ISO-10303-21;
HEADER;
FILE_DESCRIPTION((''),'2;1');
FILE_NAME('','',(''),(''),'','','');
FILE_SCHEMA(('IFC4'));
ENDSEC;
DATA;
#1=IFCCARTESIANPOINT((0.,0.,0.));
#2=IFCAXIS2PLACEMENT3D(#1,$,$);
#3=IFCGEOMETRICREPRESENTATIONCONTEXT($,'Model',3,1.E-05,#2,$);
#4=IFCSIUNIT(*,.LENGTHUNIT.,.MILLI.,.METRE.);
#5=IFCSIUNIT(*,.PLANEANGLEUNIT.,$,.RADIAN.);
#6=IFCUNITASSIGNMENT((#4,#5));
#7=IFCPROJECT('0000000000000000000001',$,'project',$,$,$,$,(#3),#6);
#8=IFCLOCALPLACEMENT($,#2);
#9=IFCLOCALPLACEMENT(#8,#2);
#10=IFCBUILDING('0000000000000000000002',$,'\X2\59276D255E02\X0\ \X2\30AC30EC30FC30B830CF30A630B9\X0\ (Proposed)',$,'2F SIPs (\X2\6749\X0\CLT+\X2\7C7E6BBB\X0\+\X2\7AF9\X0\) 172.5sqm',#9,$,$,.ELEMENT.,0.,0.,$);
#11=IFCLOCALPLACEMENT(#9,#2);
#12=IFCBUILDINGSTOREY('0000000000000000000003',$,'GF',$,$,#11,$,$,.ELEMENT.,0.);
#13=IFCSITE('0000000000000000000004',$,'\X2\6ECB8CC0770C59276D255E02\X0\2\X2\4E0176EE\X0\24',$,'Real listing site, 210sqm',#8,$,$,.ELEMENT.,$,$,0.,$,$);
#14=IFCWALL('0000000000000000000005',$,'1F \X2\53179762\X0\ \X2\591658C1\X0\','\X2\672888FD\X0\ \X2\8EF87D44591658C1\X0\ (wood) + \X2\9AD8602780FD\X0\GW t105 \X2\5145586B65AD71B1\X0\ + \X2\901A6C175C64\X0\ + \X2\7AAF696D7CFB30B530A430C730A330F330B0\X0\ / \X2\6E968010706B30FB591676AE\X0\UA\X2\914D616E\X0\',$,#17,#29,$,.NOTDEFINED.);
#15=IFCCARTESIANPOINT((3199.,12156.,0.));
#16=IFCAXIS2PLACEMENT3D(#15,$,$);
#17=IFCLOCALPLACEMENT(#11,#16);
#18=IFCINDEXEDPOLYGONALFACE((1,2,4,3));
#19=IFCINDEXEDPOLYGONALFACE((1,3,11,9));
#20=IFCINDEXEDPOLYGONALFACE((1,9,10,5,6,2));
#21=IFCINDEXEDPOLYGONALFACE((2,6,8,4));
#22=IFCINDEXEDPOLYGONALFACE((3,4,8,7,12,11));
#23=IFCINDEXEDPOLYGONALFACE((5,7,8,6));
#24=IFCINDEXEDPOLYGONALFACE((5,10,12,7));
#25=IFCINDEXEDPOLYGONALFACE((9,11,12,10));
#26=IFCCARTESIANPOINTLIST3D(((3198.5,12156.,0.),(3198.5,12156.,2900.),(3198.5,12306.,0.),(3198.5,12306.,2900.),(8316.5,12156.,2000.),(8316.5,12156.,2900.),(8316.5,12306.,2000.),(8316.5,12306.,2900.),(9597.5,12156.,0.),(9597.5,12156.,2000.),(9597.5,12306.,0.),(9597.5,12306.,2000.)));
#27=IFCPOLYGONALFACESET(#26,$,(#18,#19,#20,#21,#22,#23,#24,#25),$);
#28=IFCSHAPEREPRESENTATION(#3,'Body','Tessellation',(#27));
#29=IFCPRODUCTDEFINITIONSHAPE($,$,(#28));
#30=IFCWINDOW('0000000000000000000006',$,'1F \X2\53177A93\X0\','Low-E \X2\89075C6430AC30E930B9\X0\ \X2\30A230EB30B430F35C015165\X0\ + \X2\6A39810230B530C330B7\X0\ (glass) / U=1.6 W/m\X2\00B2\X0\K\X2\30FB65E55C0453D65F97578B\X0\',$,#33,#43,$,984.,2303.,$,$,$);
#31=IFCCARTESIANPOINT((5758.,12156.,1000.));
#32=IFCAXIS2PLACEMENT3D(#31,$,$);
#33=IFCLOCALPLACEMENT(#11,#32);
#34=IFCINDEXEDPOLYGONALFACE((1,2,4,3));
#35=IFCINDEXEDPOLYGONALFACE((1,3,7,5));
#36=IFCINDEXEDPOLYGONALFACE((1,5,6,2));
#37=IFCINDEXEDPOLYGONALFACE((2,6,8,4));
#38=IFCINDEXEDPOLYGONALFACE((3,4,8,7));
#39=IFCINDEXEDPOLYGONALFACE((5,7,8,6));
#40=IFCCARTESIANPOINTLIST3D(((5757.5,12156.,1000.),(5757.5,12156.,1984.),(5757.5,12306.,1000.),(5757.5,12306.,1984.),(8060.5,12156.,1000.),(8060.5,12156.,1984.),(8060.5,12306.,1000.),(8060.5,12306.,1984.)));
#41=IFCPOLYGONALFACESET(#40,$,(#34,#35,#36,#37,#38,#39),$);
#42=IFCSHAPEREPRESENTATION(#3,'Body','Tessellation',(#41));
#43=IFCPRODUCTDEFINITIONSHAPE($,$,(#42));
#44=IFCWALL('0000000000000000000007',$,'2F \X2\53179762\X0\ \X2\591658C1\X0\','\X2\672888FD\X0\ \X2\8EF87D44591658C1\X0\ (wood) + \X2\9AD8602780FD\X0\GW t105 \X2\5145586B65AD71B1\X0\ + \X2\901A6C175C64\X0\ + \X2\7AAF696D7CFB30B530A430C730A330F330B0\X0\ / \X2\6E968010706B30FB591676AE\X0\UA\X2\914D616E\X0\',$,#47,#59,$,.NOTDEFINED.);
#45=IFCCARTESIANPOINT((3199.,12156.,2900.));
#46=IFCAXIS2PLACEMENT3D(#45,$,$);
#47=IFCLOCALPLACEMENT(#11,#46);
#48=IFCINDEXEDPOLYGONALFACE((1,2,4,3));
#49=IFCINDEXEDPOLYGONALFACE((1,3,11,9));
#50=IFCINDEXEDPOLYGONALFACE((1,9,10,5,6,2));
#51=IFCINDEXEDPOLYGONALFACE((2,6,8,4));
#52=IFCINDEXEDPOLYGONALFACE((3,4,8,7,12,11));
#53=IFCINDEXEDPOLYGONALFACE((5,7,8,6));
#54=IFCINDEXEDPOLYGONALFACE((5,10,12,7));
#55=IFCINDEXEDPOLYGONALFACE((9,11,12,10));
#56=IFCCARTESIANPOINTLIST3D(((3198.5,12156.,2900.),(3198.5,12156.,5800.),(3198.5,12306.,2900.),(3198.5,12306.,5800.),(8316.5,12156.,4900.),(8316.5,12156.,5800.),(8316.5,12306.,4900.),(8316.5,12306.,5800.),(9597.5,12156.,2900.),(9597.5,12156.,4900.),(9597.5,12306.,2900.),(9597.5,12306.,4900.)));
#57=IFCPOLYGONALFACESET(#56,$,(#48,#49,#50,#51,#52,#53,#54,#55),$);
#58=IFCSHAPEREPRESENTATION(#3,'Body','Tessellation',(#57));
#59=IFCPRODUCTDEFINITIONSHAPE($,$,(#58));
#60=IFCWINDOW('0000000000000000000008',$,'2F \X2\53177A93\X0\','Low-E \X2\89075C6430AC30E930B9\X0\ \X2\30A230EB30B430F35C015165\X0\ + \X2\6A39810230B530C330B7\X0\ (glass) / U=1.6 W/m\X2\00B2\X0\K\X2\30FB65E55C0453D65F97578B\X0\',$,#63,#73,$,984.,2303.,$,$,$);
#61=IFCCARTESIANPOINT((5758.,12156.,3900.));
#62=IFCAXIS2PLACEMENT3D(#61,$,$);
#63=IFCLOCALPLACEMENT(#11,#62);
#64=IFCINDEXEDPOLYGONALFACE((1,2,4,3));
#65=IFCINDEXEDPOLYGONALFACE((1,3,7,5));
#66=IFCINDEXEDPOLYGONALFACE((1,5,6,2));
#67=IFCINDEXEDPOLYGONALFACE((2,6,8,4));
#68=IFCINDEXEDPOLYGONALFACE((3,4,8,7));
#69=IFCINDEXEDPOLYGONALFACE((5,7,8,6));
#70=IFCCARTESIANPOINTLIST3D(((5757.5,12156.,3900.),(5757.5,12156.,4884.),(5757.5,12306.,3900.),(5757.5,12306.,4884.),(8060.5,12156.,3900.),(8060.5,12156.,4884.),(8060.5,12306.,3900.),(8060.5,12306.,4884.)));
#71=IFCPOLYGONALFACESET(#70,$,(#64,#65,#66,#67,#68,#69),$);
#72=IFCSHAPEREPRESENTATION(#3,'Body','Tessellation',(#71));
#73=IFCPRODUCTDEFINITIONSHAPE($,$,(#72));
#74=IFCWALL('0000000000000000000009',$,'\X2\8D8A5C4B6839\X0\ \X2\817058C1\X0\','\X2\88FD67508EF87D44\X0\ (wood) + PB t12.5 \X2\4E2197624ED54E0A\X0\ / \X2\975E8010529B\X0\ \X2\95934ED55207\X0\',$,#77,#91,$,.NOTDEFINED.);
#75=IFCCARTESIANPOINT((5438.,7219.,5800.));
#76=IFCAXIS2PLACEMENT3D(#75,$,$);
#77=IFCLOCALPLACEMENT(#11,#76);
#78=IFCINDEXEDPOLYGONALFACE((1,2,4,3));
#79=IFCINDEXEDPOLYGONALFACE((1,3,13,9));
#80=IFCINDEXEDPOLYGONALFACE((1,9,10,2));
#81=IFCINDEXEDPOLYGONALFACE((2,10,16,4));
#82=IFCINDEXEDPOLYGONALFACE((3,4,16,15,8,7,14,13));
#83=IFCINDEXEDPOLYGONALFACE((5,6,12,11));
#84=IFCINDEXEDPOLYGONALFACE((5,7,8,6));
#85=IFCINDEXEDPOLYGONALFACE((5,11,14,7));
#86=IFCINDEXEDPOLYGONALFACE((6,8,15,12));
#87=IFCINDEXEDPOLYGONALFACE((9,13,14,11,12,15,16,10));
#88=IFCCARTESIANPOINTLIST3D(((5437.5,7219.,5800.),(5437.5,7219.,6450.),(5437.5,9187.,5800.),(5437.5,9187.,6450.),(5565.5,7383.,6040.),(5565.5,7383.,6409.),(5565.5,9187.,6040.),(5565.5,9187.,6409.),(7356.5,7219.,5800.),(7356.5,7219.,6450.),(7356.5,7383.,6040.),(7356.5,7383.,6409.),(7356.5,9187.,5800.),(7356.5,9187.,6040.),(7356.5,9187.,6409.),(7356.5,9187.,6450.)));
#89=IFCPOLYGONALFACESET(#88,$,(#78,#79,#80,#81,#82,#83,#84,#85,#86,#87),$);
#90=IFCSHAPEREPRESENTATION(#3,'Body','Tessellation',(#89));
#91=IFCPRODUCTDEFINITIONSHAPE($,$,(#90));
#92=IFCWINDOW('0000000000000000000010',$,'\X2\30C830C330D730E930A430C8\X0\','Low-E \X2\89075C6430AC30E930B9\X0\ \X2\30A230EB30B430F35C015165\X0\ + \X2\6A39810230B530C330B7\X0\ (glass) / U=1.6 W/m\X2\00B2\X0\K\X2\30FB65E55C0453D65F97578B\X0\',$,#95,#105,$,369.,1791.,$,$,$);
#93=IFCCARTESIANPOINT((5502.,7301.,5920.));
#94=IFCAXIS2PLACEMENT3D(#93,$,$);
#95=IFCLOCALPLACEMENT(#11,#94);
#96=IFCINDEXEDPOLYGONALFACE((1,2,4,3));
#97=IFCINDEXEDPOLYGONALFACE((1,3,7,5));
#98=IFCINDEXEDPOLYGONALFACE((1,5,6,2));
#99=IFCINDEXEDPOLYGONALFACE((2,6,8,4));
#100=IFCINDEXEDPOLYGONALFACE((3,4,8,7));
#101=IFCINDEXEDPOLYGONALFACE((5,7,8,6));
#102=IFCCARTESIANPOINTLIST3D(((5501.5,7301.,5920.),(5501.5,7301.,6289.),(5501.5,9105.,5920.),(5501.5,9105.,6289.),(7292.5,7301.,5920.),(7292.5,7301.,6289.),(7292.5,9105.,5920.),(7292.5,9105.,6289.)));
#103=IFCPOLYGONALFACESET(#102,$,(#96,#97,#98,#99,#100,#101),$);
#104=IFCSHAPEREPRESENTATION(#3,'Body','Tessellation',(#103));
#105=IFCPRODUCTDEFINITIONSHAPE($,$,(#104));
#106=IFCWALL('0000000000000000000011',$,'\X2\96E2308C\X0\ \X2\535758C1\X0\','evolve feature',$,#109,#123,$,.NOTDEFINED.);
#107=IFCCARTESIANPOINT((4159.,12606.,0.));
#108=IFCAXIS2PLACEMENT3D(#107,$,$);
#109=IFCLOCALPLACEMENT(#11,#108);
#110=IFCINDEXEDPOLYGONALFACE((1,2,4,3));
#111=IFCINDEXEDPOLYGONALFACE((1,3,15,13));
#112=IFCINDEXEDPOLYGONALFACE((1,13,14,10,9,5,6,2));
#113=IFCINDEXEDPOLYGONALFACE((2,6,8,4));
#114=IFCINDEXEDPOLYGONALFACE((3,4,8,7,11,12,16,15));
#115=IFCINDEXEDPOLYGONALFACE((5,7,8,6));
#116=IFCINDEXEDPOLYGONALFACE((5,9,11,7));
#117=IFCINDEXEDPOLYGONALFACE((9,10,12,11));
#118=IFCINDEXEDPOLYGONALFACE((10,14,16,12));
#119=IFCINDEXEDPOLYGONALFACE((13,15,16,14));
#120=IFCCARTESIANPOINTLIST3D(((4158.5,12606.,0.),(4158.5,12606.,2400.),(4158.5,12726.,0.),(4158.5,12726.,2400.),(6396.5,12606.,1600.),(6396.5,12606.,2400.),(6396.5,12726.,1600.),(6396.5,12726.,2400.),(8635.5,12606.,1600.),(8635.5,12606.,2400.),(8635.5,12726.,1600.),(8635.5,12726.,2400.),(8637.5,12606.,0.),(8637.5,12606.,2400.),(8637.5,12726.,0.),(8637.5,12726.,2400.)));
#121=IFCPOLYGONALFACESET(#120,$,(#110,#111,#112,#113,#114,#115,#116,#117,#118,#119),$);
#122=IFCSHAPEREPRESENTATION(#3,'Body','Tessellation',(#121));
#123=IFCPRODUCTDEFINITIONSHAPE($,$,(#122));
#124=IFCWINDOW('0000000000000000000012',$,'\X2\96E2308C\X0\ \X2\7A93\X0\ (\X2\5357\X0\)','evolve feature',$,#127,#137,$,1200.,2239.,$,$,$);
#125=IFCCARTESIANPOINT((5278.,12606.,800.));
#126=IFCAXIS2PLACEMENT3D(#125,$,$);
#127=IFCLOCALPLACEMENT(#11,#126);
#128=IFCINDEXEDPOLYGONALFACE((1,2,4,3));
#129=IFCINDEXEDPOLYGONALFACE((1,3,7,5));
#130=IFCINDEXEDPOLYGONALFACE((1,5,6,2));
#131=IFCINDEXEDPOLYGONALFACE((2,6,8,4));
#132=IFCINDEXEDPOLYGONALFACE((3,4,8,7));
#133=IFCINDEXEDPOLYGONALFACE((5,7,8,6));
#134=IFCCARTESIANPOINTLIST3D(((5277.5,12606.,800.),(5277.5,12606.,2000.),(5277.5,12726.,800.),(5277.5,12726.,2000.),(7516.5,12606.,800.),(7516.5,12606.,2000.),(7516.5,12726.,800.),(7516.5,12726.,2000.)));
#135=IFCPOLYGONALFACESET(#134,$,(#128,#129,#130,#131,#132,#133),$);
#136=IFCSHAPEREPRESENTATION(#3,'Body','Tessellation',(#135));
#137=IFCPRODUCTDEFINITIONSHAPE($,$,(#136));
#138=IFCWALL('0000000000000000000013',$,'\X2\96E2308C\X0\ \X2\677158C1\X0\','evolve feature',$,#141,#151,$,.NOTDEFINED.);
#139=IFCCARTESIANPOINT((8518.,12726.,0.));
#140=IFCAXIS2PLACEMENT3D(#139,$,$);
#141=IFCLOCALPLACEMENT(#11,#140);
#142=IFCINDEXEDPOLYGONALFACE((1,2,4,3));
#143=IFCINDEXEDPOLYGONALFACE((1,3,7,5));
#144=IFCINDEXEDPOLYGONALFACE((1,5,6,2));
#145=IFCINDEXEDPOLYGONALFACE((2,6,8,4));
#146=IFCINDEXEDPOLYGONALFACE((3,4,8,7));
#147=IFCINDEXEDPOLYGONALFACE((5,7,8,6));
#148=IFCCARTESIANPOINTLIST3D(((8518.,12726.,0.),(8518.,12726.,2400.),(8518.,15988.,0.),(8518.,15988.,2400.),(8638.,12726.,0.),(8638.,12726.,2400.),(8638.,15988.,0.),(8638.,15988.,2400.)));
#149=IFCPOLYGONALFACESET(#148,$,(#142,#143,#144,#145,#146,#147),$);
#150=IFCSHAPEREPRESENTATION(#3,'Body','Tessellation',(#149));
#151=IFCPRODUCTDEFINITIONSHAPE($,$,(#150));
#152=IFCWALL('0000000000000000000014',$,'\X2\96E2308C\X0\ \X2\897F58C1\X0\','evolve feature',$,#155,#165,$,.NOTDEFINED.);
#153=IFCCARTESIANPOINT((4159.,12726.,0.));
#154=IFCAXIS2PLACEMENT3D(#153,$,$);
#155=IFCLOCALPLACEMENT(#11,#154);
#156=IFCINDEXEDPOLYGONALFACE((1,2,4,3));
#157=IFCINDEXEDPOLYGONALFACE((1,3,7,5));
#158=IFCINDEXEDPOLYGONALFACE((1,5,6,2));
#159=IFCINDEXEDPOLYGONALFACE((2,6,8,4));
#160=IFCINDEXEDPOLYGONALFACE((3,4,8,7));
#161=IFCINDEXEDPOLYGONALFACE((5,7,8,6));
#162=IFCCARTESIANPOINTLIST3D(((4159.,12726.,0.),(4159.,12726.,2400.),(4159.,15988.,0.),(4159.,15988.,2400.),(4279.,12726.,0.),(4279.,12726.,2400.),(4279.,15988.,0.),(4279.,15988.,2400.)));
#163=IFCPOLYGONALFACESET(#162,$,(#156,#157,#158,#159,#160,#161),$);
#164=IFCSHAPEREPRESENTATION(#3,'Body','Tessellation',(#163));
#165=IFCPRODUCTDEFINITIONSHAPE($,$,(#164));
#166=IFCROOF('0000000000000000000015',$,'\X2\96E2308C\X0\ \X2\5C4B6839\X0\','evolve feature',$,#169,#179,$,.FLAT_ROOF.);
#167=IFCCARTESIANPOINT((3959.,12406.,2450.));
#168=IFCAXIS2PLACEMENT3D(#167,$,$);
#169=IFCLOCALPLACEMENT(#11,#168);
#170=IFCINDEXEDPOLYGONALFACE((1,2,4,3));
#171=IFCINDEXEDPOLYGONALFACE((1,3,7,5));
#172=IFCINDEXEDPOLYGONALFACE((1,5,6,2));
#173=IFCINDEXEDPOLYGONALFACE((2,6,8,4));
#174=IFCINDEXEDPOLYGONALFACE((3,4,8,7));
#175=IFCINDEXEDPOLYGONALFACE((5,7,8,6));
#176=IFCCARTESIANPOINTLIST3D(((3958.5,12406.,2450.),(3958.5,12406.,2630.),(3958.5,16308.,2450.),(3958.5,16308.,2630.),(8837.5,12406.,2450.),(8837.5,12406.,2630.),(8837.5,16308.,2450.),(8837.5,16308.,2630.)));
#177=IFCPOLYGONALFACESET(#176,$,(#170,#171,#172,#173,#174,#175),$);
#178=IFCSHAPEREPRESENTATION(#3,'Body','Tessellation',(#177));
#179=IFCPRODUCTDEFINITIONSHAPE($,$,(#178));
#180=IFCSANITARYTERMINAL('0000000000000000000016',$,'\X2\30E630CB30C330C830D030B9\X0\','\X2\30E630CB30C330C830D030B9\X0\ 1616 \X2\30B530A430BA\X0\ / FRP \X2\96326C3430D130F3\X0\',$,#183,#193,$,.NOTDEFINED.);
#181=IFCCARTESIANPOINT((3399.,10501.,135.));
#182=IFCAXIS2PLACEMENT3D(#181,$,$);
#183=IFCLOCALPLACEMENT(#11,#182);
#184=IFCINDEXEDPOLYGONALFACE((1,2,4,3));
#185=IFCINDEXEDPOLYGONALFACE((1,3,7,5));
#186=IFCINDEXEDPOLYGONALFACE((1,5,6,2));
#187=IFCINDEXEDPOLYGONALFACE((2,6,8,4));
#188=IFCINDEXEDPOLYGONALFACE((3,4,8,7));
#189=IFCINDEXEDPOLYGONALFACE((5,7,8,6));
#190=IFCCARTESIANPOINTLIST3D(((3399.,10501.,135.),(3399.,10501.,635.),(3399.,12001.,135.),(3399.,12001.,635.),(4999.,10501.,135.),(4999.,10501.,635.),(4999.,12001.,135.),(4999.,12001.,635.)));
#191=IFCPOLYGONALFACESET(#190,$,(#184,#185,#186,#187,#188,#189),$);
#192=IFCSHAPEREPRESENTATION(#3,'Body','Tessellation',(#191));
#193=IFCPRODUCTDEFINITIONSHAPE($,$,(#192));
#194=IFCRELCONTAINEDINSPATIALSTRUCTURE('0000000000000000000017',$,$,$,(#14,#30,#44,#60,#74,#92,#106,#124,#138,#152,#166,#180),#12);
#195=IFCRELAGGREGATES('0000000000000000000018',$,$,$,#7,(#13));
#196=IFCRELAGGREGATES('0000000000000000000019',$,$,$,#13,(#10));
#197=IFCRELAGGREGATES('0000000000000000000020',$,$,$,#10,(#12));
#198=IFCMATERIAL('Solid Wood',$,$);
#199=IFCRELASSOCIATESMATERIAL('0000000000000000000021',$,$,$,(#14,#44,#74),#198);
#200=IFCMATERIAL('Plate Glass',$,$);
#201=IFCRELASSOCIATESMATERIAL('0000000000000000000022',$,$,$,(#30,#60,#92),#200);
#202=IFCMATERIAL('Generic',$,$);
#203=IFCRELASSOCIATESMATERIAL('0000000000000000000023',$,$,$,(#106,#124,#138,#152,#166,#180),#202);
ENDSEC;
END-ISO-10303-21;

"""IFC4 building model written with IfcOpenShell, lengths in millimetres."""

from ifc_helpers import new_model, si_unit, frame, frame_2d, origin, place, context, project, spatial, rectangle, extrude, material, element, fill, save


model = new_model("IFC4")

# Units and contexts
model_context = context("Model", 3, precision=1e-05, world=origin())
ifc_project = project(units=[si_unit("LENGTHUNIT", "METRE", prefix="MILLI"), si_unit("PLANEANGLEUNIT", "RADIAN")], contexts=[model_context])

# Site, building, storey
site_placement = place(None, origin())
site = spatial("IfcSite", under=ifc_project, at=site_placement, Name="滋賀県大津市2丁目24", ObjectType="Real listing site, 210sqm", CompositionType="ELEMENT", RefElevation=0.0)
building_placement = place(site_placement, origin())
building = spatial("IfcBuilding", under=site, at=building_placement, Name="大津市 ガレージハウス (Proposed)", ObjectType="2F SIPs (杉CLT+籾殻+竹) 172.5sqm", CompositionType="ELEMENT", ElevationOfRefHeight=0.0, ElevationOfTerrain=0.0)
storey_placement = place(building_placement, origin())
storey = spatial("IfcBuildingStorey", under=building, at=storey_placement, Name="GF", CompositionType="ELEMENT", Elevation=0.0)

# Shared definitions
ifc_material_1 = material(Name="Generic")

# Wall, opening, window
ifc_material_2 = material(Name="Solid Wood")
wall_1_placement = place(storey_placement, frame((3199.0, 12156.0, 0.0)))
wall_1 = element("IfcWall", 1, at=wall_1_placement, inside=storey, material=ifc_material_2, Name="1F 北面 外壁", Description="木製 軸組外壁 (wood) + 高性能GW t105 充填断熱 + 通気層 + 窯業系サイディング / 準耐火・外皮UA配慮", PredefinedType="NOTDEFINED", context=model_context, shape_type="SweptSolid", body=[
    extrude(rectangle(XDim=6399.0, YDim=150.0, at=frame_2d((3199.0, 75.0))), frame((3199.0, 12156.0, 0.0)), (0.0, 0.0, 1.0), 2900.0),
])
opening_1_placement = place(storey_placement, frame((5758.0, 12156.0, 1000.0)))
opening_1 = element("IfcOpeningElement", 2, at=opening_1_placement, cuts=wall_1, PredefinedType="NOTDEFINED", context=model_context, shape_type="SweptSolid", body=[
    extrude(rectangle(XDim=2303.0, YDim=150.0, at=frame_2d((1151.0, 75.0))), frame((5758.0, 12156.0, 1000.0)), (0.0, 0.0, 1.0), 984.0),
])
ifc_material_3 = material(Name="Plate Glass")
window_1_placement = place(storey_placement, frame((5758.0, 12156.0, 1000.0)))
window_1 = element("IfcWindow", 3, at=window_1_placement, inside=storey, material=ifc_material_3, Name="1F 北窓", Description="Low-E 複層ガラス アルゴン封入 + 樹脂サッシ (glass) / U=1.6 W/m²K・日射取得型", OverallHeight=984.0, OverallWidth=2303.0, context=model_context, shape_type="SweptSolid", body=[
    extrude(rectangle(XDim=2303.0, YDim=150.0, at=frame_2d((1151.0, 75.0))), frame((5758.0, 12156.0, 1000.0)), (0.0, 0.0, 1.0), 984.0),
])
fill(opening_1, window_1)

# Wall, opening, window
wall_2_placement = place(storey_placement, frame((3199.0, 12156.0, 2900.0)))
wall_2 = element("IfcWall", 4, at=wall_2_placement, inside=storey, material=ifc_material_2, Name="2F 北面 外壁", Description="木製 軸組外壁 (wood) + 高性能GW t105 充填断熱 + 通気層 + 窯業系サイディング / 準耐火・外皮UA配慮", PredefinedType="NOTDEFINED", context=model_context, shape_type="SweptSolid", body=[
    extrude(rectangle(XDim=6399.0, YDim=150.0, at=frame_2d((3199.0, 75.0))), frame((3199.0, 12156.0, 2900.0)), (0.0, 0.0, 1.0), 2900.0),
])
opening_2_placement = place(storey_placement, frame((5758.0, 12156.0, 3900.0)))
opening_2 = element("IfcOpeningElement", 5, at=opening_2_placement, cuts=wall_2, PredefinedType="NOTDEFINED", context=model_context, shape_type="SweptSolid", body=[
    extrude(rectangle(XDim=2303.0, YDim=150.0, at=frame_2d((1151.0, 75.0))), frame((5758.0, 12156.0, 3900.0)), (0.0, 0.0, 1.0), 984.0),
])
window_2_placement = place(storey_placement, frame((5758.0, 12156.0, 3900.0)))
window_2 = element("IfcWindow", 6, at=window_2_placement, inside=storey, material=ifc_material_3, Name="2F 北窓", Description="Low-E 複層ガラス アルゴン封入 + 樹脂サッシ (glass) / U=1.6 W/m²K・日射取得型", OverallHeight=984.0, OverallWidth=2303.0, context=model_context, shape_type="SweptSolid", body=[
    extrude(rectangle(XDim=2303.0, YDim=150.0, at=frame_2d((1151.0, 75.0))), frame((5758.0, 12156.0, 3900.0)), (0.0, 0.0, 1.0), 984.0),
])
fill(opening_2, window_2)

# Walls, openings, windows
wall_3_placement = place(storey_placement, frame((5438.0, 7219.0, 5800.0)))
wall_3 = element("IfcWall", 7, at=wall_3_placement, inside=storey, material=ifc_material_2, Name="越屋根 腰壁", Description="製材軸組 (wood) + PB t12.5 両面仕上 / 非耐力 間仕切", PredefinedType="NOTDEFINED", context=model_context, shape_type="SweptSolid", body=[
    extrude(rectangle(XDim=1919.0, YDim=1968.0, at=frame_2d((959.0, 984.0))), frame((5438.0, 7219.0, 5800.0)), (0.0, 0.0, 1.0), 650.0),
])
opening_3_placement = place(storey_placement, frame((5502.0, 7301.0, 5920.0)))
opening_3 = element("IfcOpeningElement", 8, at=opening_3_placement, cuts=wall_3, PredefinedType="NOTDEFINED", context=model_context, shape_type="SweptSolid", body=[
    extrude(rectangle(XDim=1791.0, YDim=1804.0, at=frame_2d((895.0, 902.0))), frame((5502.0, 7301.0, 5920.0)), (0.0, 0.0, 1.0), 369.0),
])
window_3_placement = place(storey_placement, frame((5502.0, 7301.0, 5920.0)))
window_3 = element("IfcWindow", 9, at=window_3_placement, inside=storey, material=ifc_material_3, Name="トップライト", Description="Low-E 複層ガラス アルゴン封入 + 樹脂サッシ (glass) / U=1.6 W/m²K・日射取得型", OverallHeight=369.0, OverallWidth=1791.0, context=model_context, shape_type="SweptSolid", body=[
    extrude(rectangle(XDim=1791.0, YDim=1804.0, at=frame_2d((895.0, 902.0))), frame((5502.0, 7301.0, 5920.0)), (0.0, 0.0, 1.0), 369.0),
])
fill(opening_3, window_3)
wall_4_placement = place(storey_placement, frame((4159.0, 12606.0, 0.0)))
wall_4 = element("IfcWall", 10, at=wall_4_placement, inside=storey, material=ifc_material_1, Name="離れ 南壁", Description="evolve feature", PredefinedType="NOTDEFINED", context=model_context, shape_type="SweptSolid", body=[
    extrude(rectangle(XDim=4479.0, YDim=120.0, at=frame_2d((2239.0, 60.0))), frame((4159.0, 12606.0, 0.0)), (0.0, 0.0, 1.0), 2400.0),
])
opening_4_placement = place(storey_placement, frame((5278.0, 12606.0, 800.0)))
opening_4 = element("IfcOpeningElement", 11, at=opening_4_placement, cuts=wall_4, PredefinedType="NOTDEFINED", context=model_context, shape_type="SweptSolid", body=[
    extrude(rectangle(XDim=2239.0, YDim=120.0, at=frame_2d((1119.0, 60.0))), frame((5278.0, 12606.0, 800.0)), (0.0, 0.0, 1.0), 1200.0),
])
window_4_placement = place(storey_placement, frame((5278.0, 12606.0, 800.0)))
window_4 = element("IfcWindow", 12, at=window_4_placement, inside=storey, material=ifc_material_1, Name="離れ 窓 (南)", Description="evolve feature", OverallHeight=1200.0, OverallWidth=2239.0, context=model_context, shape_type="SweptSolid", body=[
    extrude(rectangle(XDim=2239.0, YDim=120.0, at=frame_2d((1119.0, 60.0))), frame((5278.0, 12606.0, 800.0)), (0.0, 0.0, 1.0), 1200.0),
])
fill(opening_4, window_4)

# Walls
wall_5_placement = place(storey_placement, frame((8518.0, 12726.0, 0.0)))
element("IfcWall", 13, at=wall_5_placement, inside=storey, material=ifc_material_1, Name="離れ 東壁", Description="evolve feature", PredefinedType="NOTDEFINED", context=model_context, shape_type="SweptSolid", body=[
    extrude(rectangle(XDim=120.0, YDim=3262.0, at=frame_2d((60.0, 1631.0))), frame((8518.0, 12726.0, 0.0)), (0.0, 0.0, 1.0), 2400.0),
])
wall_6_placement = place(storey_placement, frame((4159.0, 12726.0, 0.0)))
element("IfcWall", 14, at=wall_6_placement, inside=storey, material=ifc_material_1, Name="離れ 西壁", Description="evolve feature", PredefinedType="NOTDEFINED", context=model_context, shape_type="SweptSolid", body=[
    extrude(rectangle(XDim=120.0, YDim=3262.0, at=frame_2d((60.0, 1631.0))), frame((4159.0, 12726.0, 0.0)), (0.0, 0.0, 1.0), 2400.0),
])

# Roof
roof_1_placement = place(storey_placement, frame((3959.0, 12406.0, 2450.0)))
element("IfcRoof", 15, at=roof_1_placement, inside=storey, material=ifc_material_1, Name="離れ 屋根", Description="evolve feature", PredefinedType="FLAT_ROOF", context=model_context, shape_type="SweptSolid", body=[
    extrude(rectangle(XDim=4879.0, YDim=3902.0, at=frame_2d((2439.0, 1951.0))), frame((3959.0, 12406.0, 2450.0)), (0.0, 0.0, 1.0), 180.0),
])

# Sanitary terminal
sanitary_terminal_1_placement = place(storey_placement, frame((3399.0, 10501.0, 135.0)))
element("IfcSanitaryTerminal", 16, at=sanitary_terminal_1_placement, inside=storey, material=ifc_material_1, Name="ユニットバス", Description="ユニットバス 1616 サイズ / FRP 防水パン", PredefinedType="NOTDEFINED", context=model_context, shape_type="SweptSolid", body=[
    extrude(rectangle(XDim=1600.0, YDim=1500.0, at=frame_2d((800.0, 750.0))), frame((3399.0, 10501.0, 135.0)), (0.0, 0.0, 1.0), 500.0),
])

save(model, "model.ifc")
